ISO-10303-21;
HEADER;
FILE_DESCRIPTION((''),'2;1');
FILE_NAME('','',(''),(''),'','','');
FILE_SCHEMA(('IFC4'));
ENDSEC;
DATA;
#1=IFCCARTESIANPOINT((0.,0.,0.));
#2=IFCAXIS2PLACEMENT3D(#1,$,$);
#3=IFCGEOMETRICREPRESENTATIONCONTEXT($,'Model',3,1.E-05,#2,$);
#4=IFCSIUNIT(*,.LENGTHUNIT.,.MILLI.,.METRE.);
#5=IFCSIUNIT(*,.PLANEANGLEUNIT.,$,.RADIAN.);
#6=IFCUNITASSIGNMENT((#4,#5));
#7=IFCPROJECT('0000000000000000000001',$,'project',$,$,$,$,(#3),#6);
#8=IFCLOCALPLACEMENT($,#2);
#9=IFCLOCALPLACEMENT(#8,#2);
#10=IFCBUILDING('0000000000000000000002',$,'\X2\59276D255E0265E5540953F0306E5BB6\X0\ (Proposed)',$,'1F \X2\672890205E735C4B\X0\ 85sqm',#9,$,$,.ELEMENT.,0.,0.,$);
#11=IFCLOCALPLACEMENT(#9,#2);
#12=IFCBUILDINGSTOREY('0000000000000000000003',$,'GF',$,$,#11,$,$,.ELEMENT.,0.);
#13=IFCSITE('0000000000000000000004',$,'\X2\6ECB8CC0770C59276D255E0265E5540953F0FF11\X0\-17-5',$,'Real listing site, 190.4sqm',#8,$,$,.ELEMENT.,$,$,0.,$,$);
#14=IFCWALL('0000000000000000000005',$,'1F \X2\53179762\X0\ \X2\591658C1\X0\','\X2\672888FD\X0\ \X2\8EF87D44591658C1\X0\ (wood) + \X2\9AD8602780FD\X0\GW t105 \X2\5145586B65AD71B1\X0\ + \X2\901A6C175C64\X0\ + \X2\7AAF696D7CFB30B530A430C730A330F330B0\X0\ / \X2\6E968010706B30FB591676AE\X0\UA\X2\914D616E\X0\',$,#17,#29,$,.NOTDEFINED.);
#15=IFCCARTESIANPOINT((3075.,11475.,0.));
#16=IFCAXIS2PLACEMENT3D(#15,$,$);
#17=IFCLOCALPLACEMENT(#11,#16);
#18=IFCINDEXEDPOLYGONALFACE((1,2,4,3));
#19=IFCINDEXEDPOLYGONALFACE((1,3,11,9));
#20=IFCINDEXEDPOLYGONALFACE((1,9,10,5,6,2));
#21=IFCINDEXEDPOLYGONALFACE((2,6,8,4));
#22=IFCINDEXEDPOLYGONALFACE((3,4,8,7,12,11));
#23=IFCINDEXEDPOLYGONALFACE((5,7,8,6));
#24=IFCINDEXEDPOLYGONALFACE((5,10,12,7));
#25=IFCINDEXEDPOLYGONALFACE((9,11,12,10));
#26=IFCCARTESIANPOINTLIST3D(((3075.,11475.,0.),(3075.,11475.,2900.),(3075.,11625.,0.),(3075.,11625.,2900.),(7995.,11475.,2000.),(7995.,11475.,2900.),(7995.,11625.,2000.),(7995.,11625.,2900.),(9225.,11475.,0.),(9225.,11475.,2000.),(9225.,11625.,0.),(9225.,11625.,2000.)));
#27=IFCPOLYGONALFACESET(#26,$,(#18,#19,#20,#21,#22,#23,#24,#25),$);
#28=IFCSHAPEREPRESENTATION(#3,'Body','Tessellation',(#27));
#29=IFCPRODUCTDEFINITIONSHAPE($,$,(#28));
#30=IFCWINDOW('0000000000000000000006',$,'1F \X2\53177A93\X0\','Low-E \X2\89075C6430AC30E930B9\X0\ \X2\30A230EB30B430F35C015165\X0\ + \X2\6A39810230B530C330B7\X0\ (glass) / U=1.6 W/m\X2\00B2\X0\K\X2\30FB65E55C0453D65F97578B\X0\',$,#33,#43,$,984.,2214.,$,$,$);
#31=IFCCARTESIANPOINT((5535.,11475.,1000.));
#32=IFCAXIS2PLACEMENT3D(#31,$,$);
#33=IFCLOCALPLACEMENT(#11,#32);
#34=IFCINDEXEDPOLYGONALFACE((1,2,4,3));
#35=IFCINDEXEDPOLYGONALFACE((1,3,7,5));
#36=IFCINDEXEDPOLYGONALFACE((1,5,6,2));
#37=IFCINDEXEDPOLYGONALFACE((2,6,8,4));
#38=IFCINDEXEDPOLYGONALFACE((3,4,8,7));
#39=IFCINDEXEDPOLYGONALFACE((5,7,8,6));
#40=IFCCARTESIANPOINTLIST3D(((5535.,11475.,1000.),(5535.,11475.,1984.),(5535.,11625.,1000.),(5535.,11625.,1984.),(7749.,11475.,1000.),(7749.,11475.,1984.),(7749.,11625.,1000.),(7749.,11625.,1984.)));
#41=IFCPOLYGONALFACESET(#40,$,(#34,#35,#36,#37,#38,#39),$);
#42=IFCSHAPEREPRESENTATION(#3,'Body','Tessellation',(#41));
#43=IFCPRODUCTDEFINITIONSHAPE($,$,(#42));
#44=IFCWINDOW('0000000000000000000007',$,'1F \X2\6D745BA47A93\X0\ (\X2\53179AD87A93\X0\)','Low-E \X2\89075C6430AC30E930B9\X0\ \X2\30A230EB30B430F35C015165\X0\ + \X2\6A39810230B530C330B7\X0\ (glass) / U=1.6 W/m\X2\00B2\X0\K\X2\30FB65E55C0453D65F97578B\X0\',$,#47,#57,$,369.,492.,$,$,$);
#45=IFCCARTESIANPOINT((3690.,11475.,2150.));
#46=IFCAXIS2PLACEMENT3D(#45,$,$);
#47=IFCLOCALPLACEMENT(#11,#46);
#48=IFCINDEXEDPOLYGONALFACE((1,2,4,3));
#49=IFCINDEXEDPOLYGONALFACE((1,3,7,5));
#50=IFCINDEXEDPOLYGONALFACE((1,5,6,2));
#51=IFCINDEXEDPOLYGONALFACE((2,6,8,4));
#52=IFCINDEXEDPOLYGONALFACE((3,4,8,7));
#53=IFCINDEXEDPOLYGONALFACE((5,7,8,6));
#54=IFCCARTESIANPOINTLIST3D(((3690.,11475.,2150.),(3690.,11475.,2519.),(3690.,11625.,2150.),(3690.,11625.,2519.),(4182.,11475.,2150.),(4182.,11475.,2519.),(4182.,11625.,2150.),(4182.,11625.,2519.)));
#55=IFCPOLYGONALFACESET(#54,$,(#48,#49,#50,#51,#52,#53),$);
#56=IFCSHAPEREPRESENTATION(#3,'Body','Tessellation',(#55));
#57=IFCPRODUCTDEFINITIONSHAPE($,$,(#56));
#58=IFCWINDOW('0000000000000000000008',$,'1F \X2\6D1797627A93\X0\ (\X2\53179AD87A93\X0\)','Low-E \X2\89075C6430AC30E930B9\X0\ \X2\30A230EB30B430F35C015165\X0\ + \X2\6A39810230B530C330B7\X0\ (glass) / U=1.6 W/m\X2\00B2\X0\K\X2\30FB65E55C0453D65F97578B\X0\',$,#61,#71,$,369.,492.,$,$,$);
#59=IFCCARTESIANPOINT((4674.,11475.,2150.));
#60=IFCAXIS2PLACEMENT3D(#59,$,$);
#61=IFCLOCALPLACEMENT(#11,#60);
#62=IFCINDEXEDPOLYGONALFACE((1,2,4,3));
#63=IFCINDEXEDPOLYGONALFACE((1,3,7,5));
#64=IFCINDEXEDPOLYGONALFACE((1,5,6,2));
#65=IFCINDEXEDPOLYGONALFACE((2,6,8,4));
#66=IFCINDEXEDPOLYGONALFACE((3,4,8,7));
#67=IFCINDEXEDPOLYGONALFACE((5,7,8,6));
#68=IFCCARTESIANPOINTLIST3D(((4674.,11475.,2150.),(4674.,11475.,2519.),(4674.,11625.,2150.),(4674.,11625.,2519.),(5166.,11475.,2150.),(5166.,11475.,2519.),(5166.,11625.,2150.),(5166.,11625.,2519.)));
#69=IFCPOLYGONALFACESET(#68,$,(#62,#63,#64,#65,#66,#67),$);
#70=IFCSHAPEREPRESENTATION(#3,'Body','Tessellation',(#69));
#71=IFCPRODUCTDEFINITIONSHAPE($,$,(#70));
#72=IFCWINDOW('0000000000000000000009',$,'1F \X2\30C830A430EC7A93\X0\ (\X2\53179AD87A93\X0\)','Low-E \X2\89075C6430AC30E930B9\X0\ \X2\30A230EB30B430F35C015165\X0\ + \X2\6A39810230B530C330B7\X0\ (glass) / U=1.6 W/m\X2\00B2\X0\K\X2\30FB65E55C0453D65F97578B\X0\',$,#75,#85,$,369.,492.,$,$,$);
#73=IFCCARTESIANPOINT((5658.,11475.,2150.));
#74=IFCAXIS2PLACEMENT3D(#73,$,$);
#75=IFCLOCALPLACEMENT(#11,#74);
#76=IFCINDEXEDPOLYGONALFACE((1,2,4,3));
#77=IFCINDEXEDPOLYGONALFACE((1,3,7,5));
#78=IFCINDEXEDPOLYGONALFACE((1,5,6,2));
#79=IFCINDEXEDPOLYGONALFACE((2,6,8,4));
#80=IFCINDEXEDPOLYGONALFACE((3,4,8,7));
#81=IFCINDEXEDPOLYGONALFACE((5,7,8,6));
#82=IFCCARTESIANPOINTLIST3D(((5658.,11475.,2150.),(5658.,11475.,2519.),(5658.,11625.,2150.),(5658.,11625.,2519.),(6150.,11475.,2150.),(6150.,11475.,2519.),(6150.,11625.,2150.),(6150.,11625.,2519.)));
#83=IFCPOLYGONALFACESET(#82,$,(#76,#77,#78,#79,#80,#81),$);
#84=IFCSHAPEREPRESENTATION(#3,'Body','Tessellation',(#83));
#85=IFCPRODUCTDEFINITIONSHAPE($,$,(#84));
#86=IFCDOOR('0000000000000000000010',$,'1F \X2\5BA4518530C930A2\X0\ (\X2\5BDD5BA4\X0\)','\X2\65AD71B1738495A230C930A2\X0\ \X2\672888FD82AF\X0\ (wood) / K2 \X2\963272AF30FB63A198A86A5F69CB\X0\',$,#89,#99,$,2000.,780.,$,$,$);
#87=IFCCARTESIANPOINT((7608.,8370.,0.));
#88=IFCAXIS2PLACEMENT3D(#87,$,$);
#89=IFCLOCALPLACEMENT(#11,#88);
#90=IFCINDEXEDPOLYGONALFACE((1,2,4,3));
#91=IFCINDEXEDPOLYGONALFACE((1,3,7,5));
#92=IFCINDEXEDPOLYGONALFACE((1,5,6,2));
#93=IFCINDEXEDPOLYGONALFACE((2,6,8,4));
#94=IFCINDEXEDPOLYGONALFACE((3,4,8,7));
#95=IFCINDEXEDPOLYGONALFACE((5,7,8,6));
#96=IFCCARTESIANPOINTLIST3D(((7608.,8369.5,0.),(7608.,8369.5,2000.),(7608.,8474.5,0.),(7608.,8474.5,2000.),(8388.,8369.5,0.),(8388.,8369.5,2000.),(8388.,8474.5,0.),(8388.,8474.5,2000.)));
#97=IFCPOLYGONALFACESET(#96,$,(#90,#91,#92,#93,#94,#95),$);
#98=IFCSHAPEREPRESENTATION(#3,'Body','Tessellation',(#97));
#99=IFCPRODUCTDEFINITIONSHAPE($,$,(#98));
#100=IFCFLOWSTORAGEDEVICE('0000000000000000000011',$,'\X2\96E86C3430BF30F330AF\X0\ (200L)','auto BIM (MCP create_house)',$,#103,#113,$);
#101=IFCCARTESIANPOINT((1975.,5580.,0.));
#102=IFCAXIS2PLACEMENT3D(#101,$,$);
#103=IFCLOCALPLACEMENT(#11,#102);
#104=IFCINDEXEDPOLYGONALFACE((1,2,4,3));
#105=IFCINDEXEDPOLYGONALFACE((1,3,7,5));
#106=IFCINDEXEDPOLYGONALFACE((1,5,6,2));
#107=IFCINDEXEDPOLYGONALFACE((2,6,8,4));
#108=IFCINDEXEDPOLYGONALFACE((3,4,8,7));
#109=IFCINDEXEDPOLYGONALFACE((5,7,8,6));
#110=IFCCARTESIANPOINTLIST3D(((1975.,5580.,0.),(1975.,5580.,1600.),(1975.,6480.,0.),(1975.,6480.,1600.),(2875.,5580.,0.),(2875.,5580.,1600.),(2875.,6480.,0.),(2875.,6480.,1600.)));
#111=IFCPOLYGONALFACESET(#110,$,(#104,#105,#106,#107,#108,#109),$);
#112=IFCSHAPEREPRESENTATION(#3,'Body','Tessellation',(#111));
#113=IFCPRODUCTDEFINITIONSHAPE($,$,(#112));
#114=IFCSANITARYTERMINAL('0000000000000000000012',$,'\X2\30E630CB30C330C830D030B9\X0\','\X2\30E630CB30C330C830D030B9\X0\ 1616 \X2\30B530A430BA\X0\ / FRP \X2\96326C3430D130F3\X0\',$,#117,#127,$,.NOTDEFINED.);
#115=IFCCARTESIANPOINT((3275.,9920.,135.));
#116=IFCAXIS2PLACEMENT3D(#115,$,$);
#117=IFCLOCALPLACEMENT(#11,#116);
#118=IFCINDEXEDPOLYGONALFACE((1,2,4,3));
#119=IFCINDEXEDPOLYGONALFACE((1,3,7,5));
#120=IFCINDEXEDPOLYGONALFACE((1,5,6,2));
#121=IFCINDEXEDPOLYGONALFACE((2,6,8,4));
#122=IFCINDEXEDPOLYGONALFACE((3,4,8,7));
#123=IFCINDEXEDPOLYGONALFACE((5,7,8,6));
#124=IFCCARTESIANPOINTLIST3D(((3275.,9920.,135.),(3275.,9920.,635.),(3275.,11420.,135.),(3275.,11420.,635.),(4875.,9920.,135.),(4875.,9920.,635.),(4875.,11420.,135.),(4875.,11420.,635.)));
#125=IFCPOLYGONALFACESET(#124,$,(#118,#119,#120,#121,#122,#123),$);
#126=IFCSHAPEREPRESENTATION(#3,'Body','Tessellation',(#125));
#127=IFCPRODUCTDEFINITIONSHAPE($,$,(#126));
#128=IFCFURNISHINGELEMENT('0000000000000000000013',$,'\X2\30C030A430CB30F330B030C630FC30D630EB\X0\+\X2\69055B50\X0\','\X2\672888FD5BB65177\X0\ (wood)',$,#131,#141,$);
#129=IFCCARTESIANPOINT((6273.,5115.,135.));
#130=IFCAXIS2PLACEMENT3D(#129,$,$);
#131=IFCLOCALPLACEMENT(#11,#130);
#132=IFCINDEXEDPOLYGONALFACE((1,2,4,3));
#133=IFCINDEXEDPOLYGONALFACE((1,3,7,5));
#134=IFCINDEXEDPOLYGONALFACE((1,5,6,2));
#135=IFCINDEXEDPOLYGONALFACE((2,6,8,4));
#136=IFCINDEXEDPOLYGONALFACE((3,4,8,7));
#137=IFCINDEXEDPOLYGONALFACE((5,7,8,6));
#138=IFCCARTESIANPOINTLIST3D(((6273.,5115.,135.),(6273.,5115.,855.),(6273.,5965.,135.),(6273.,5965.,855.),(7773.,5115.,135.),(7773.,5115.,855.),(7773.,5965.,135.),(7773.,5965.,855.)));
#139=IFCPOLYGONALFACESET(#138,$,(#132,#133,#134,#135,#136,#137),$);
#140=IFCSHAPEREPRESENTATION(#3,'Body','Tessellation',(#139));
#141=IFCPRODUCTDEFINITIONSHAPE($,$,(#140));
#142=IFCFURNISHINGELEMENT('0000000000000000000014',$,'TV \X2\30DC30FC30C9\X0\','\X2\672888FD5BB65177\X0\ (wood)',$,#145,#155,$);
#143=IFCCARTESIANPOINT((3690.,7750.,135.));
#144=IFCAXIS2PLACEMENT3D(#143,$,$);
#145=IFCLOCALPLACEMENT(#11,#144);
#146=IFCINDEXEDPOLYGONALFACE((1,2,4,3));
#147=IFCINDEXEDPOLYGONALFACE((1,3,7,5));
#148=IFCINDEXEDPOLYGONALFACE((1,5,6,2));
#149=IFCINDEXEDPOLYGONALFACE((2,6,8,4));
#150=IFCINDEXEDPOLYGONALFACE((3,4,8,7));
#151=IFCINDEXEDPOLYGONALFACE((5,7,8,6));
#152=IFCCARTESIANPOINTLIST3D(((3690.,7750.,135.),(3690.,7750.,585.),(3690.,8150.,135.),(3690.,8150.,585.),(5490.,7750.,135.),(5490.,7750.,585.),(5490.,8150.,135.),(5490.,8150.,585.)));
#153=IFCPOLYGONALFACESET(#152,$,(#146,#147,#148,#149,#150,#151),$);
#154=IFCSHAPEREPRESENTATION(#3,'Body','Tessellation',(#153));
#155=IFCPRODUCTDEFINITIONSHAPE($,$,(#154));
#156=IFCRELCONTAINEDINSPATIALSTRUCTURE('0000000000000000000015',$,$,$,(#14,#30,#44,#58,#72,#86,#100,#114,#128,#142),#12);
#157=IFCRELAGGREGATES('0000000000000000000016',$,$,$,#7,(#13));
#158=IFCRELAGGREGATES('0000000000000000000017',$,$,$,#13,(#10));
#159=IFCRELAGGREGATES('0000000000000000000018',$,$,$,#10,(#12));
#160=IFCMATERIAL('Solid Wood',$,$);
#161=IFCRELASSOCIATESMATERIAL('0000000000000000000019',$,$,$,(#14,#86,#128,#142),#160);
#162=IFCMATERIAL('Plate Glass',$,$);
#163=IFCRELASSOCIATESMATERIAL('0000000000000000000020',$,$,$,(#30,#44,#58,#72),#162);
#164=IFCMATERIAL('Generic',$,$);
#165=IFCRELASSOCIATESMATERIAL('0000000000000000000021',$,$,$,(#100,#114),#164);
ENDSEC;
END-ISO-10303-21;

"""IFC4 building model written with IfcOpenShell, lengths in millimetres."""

from ifc_helpers import new_model, si_unit, frame, frame_2d, origin, place, context, project, spatial, rectangle, extrude, material, element, fill, save


model = new_model("IFC4")

# Units and contexts
model_context = context("Model", 3, precision=1e-05, world=origin())
ifc_project = project(units=[si_unit("LENGTHUNIT", "METRE", prefix="MILLI"), si_unit("PLANEANGLEUNIT", "RADIAN")], contexts=[model_context])

# Site, building, storey
site_placement = place(None, origin())
site = spatial("IfcSite", under=ifc_project, at=site_placement, Name="滋賀県大津市日吉台１-17-5", ObjectType="Real listing site, 190.4sqm", CompositionType="ELEMENT", RefElevation=0.0)
building_placement = place(site_placement, origin())
building = spatial("IfcBuilding", under=site, at=building_placement, Name="大津市日吉台の家 (Proposed)", ObjectType="1F 木造平屋 85sqm", CompositionType="ELEMENT", ElevationOfRefHeight=0.0, ElevationOfTerrain=0.0)
storey_placement = place(building_placement, origin())
storey = spatial("IfcBuildingStorey", under=building, at=storey_placement, Name="GF", CompositionType="ELEMENT", Elevation=0.0)

# Wall, openings, windows
ifc_material_1 = material(Name="Solid Wood")
wall_1_placement = place(storey_placement, frame((3075.0, 11475.0, 0.0)))
wall_1 = element("IfcWall", 1, at=wall_1_placement, inside=storey, material=ifc_material_1, Name="1F 北面 外壁", Description="木製 軸組外壁 (wood) + 高性能GW t105 充填断熱 + 通気層 + 窯業系サイディング / 準耐火・外皮UA配慮", PredefinedType="NOTDEFINED", context=model_context, shape_type="SweptSolid", body=[
    extrude(rectangle(XDim=6150.0, YDim=150.0, at=frame_2d((3075.0, 75.0))), frame((3075.0, 11475.0, 0.0)), (0.0, 0.0, 1.0), 2900.0),
])
opening_1_placement = place(storey_placement, frame((5535.0, 11475.0, 1000.0)))
opening_1 = element("IfcOpeningElement", 2, at=opening_1_placement, cuts=wall_1, PredefinedType="NOTDEFINED", context=model_context, shape_type="SweptSolid", body=[
    extrude(rectangle(XDim=2214.0, YDim=150.0, at=frame_2d((1107.0, 75.0))), frame((5535.0, 11475.0, 1000.0)), (0.0, 0.0, 1.0), 984.0),
])
opening_2_placement = place(storey_placement, frame((3690.0, 11475.0, 2150.0)))
opening_2 = element("IfcOpeningElement", 3, at=opening_2_placement, cuts=wall_1, PredefinedType="NOTDEFINED", context=model_context, shape_type="SweptSolid", body=[
    extrude(rectangle(XDim=492.0, YDim=150.0, at=frame_2d((246.0, 75.0))), frame((3690.0, 11475.0, 2150.0)), (0.0, 0.0, 1.0), 369.0),
])
opening_3_placement = place(storey_placement, frame((4674.0, 11475.0, 2150.0)))
opening_3 = element("IfcOpeningElement", 4, at=opening_3_placement, cuts=wall_1, PredefinedType="NOTDEFINED", context=model_context, shape_type="SweptSolid", body=[
    extrude(rectangle(XDim=492.0, YDim=150.0, at=frame_2d((246.0, 75.0))), frame((4674.0, 11475.0, 2150.0)), (0.0, 0.0, 1.0), 369.0),
])
opening_4_placement = place(storey_placement, frame((5658.0, 11475.0, 2150.0)))
opening_4 = element("IfcOpeningElement", 5, at=opening_4_placement, cuts=wall_1, PredefinedType="NOTDEFINED", context=model_context, shape_type="SweptSolid", body=[
    extrude(rectangle(XDim=492.0, YDim=150.0, at=frame_2d((246.0, 75.0))), frame((5658.0, 11475.0, 2150.0)), (0.0, 0.0, 1.0), 369.0),
])
ifc_material_2 = material(Name="Plate Glass")
window_1_placement = place(storey_placement, frame((5535.0, 11475.0, 1000.0)))
window_1 = element("IfcWindow", 6, at=window_1_placement, inside=storey, material=ifc_material_2, Name="1F 北窓", Description="Low-E 複層ガラス アルゴン封入 + 樹脂サッシ (glass) / U=1.6 W/m²K・日射取得型", OverallHeight=984.0, OverallWidth=2214.0, context=model_context, shape_type="SweptSolid", body=[
    extrude(rectangle(XDim=2214.0, YDim=150.0, at=frame_2d((1107.0, 75.0))), frame((5535.0, 11475.0, 1000.0)), (0.0, 0.0, 1.0), 984.0),
])
fill(opening_1, window_1)
window_2_placement = place(storey_placement, frame((3690.0, 11475.0, 2150.0)))
window_2 = element("IfcWindow", 7, at=window_2_placement, inside=storey, material=ifc_material_2, Name="1F 浴室窓 (北高窓)", Description="Low-E 複層ガラス アルゴン封入 + 樹脂サッシ (glass) / U=1.6 W/m²K・日射取得型", OverallHeight=369.0, OverallWidth=492.0, context=model_context, shape_type="SweptSolid", body=[
    extrude(rectangle(XDim=492.0, YDim=150.0, at=frame_2d((246.0, 75.0))), frame((3690.0, 11475.0, 2150.0)), (0.0, 0.0, 1.0), 369.0),
])
fill(opening_2, window_2)
window_3_placement = place(storey_placement, frame((4674.0, 11475.0, 2150.0)))
window_3 = element("IfcWindow", 8, at=window_3_placement, inside=storey, material=ifc_material_2, Name="1F 洗面窓 (北高窓)", Description="Low-E 複層ガラス アルゴン封入 + 樹脂サッシ (glass) / U=1.6 W/m²K・日射取得型", OverallHeight=369.0, OverallWidth=492.0, context=model_context, shape_type="SweptSolid", body=[
    extrude(rectangle(XDim=492.0, YDim=150.0, at=frame_2d((246.0, 75.0))), frame((4674.0, 11475.0, 2150.0)), (0.0, 0.0, 1.0), 369.0),
])
fill(opening_3, window_3)
window_4_placement = place(storey_placement, frame((5658.0, 11475.0, 2150.0)))
window_4 = element("IfcWindow", 9, at=window_4_placement, inside=storey, material=ifc_material_2, Name="1F トイレ窓 (北高窓)", Description="Low-E 複層ガラス アルゴン封入 + 樹脂サッシ (glass) / U=1.6 W/m²K・日射取得型", OverallHeight=369.0, OverallWidth=492.0, context=model_context, shape_type="SweptSolid", body=[
    extrude(rectangle(XDim=492.0, YDim=150.0, at=frame_2d((246.0, 75.0))), frame((5658.0, 11475.0, 2150.0)), (0.0, 0.0, 1.0), 369.0),
])
fill(opening_4, window_4)

# Door
door_1_placement = place(storey_placement, frame((7608.0, 8370.0, 0.0)))
element("IfcDoor", 10, at=door_1_placement, inside=storey, material=ifc_material_1, Name="1F 室内ドア (寝室)", Description="断熱玄関ドア 木製芯 (wood) / K2 防犯・採風機構", OverallHeight=2000.0, OverallWidth=780.0, context=model_context, shape_type="SweptSolid", body=[
    extrude(rectangle(XDim=780.0, YDim=105.0, at=frame_2d((390.0, 52.0))), frame((7608.0, 8370.0, 0.0)), (0.0, 0.0, 1.0), 2000.0),
])

# Flow storage device
ifc_material_3 = material(Name="Generic")
flow_storage_device_placement = place(storey_placement, frame((1975.0, 5580.0, 0.0)))
element("IfcFlowStorageDevice", 11, at=flow_storage_device_placement, inside=storey, material=ifc_material_3, Name="雨水タンク (200L)", Description="auto BIM (MCP create_house)", context=model_context, shape_type="SweptSolid", body=[
    extrude(rectangle(XDim=900.0, YDim=900.0, at=frame_2d((450.0, 450.0))), frame((1975.0, 5580.0, 0.0)), (0.0, 0.0, 1.0), 1600.0),
])

# Sanitary terminal
sanitary_terminal_placement = place(storey_placement, frame((3275.0, 9920.0, 135.0)))
element("IfcSanitaryTerminal", 12, at=sanitary_terminal_placement, inside=storey, material=ifc_material_3, Name="ユニットバス", Description="ユニットバス 1616 サイズ / FRP 防水パン", PredefinedType="NOTDEFINED", context=model_context, shape_type="SweptSolid", body=[
    extrude(rectangle(XDim=1600.0, YDim=1500.0, at=frame_2d((800.0, 750.0))), frame((3275.0, 9920.0, 135.0)), (0.0, 0.0, 1.0), 500.0),
])

# Furnishing elements
furnishing_1_placement = place(storey_placement, frame((6273.0, 5115.0, 135.0)))
element("IfcFurnishingElement", 13, at=furnishing_1_placement, inside=storey, material=ifc_material_1, Name="ダイニングテーブル+椅子", Description="木製家具 (wood)", context=model_context, shape_type="SweptSolid", body=[
    extrude(rectangle(XDim=1500.0, YDim=850.0, at=frame_2d((750.0, 425.0))), frame((6273.0, 5115.0, 135.0)), (0.0, 0.0, 1.0), 720.0),
])
furnishing_2_placement = place(storey_placement, frame((3690.0, 7750.0, 135.0)))
element("IfcFurnishingElement", 14, at=furnishing_2_placement, inside=storey, material=ifc_material_1, Name="TV ボード", Description="木製家具 (wood)", context=model_context, shape_type="SweptSolid", body=[
    extrude(rectangle(XDim=1800.0, YDim=400.0, at=frame_2d((900.0, 200.0))), frame((3690.0, 7750.0, 135.0)), (0.0, 0.0, 1.0), 450.0),
])

save(model, "model.ifc")
